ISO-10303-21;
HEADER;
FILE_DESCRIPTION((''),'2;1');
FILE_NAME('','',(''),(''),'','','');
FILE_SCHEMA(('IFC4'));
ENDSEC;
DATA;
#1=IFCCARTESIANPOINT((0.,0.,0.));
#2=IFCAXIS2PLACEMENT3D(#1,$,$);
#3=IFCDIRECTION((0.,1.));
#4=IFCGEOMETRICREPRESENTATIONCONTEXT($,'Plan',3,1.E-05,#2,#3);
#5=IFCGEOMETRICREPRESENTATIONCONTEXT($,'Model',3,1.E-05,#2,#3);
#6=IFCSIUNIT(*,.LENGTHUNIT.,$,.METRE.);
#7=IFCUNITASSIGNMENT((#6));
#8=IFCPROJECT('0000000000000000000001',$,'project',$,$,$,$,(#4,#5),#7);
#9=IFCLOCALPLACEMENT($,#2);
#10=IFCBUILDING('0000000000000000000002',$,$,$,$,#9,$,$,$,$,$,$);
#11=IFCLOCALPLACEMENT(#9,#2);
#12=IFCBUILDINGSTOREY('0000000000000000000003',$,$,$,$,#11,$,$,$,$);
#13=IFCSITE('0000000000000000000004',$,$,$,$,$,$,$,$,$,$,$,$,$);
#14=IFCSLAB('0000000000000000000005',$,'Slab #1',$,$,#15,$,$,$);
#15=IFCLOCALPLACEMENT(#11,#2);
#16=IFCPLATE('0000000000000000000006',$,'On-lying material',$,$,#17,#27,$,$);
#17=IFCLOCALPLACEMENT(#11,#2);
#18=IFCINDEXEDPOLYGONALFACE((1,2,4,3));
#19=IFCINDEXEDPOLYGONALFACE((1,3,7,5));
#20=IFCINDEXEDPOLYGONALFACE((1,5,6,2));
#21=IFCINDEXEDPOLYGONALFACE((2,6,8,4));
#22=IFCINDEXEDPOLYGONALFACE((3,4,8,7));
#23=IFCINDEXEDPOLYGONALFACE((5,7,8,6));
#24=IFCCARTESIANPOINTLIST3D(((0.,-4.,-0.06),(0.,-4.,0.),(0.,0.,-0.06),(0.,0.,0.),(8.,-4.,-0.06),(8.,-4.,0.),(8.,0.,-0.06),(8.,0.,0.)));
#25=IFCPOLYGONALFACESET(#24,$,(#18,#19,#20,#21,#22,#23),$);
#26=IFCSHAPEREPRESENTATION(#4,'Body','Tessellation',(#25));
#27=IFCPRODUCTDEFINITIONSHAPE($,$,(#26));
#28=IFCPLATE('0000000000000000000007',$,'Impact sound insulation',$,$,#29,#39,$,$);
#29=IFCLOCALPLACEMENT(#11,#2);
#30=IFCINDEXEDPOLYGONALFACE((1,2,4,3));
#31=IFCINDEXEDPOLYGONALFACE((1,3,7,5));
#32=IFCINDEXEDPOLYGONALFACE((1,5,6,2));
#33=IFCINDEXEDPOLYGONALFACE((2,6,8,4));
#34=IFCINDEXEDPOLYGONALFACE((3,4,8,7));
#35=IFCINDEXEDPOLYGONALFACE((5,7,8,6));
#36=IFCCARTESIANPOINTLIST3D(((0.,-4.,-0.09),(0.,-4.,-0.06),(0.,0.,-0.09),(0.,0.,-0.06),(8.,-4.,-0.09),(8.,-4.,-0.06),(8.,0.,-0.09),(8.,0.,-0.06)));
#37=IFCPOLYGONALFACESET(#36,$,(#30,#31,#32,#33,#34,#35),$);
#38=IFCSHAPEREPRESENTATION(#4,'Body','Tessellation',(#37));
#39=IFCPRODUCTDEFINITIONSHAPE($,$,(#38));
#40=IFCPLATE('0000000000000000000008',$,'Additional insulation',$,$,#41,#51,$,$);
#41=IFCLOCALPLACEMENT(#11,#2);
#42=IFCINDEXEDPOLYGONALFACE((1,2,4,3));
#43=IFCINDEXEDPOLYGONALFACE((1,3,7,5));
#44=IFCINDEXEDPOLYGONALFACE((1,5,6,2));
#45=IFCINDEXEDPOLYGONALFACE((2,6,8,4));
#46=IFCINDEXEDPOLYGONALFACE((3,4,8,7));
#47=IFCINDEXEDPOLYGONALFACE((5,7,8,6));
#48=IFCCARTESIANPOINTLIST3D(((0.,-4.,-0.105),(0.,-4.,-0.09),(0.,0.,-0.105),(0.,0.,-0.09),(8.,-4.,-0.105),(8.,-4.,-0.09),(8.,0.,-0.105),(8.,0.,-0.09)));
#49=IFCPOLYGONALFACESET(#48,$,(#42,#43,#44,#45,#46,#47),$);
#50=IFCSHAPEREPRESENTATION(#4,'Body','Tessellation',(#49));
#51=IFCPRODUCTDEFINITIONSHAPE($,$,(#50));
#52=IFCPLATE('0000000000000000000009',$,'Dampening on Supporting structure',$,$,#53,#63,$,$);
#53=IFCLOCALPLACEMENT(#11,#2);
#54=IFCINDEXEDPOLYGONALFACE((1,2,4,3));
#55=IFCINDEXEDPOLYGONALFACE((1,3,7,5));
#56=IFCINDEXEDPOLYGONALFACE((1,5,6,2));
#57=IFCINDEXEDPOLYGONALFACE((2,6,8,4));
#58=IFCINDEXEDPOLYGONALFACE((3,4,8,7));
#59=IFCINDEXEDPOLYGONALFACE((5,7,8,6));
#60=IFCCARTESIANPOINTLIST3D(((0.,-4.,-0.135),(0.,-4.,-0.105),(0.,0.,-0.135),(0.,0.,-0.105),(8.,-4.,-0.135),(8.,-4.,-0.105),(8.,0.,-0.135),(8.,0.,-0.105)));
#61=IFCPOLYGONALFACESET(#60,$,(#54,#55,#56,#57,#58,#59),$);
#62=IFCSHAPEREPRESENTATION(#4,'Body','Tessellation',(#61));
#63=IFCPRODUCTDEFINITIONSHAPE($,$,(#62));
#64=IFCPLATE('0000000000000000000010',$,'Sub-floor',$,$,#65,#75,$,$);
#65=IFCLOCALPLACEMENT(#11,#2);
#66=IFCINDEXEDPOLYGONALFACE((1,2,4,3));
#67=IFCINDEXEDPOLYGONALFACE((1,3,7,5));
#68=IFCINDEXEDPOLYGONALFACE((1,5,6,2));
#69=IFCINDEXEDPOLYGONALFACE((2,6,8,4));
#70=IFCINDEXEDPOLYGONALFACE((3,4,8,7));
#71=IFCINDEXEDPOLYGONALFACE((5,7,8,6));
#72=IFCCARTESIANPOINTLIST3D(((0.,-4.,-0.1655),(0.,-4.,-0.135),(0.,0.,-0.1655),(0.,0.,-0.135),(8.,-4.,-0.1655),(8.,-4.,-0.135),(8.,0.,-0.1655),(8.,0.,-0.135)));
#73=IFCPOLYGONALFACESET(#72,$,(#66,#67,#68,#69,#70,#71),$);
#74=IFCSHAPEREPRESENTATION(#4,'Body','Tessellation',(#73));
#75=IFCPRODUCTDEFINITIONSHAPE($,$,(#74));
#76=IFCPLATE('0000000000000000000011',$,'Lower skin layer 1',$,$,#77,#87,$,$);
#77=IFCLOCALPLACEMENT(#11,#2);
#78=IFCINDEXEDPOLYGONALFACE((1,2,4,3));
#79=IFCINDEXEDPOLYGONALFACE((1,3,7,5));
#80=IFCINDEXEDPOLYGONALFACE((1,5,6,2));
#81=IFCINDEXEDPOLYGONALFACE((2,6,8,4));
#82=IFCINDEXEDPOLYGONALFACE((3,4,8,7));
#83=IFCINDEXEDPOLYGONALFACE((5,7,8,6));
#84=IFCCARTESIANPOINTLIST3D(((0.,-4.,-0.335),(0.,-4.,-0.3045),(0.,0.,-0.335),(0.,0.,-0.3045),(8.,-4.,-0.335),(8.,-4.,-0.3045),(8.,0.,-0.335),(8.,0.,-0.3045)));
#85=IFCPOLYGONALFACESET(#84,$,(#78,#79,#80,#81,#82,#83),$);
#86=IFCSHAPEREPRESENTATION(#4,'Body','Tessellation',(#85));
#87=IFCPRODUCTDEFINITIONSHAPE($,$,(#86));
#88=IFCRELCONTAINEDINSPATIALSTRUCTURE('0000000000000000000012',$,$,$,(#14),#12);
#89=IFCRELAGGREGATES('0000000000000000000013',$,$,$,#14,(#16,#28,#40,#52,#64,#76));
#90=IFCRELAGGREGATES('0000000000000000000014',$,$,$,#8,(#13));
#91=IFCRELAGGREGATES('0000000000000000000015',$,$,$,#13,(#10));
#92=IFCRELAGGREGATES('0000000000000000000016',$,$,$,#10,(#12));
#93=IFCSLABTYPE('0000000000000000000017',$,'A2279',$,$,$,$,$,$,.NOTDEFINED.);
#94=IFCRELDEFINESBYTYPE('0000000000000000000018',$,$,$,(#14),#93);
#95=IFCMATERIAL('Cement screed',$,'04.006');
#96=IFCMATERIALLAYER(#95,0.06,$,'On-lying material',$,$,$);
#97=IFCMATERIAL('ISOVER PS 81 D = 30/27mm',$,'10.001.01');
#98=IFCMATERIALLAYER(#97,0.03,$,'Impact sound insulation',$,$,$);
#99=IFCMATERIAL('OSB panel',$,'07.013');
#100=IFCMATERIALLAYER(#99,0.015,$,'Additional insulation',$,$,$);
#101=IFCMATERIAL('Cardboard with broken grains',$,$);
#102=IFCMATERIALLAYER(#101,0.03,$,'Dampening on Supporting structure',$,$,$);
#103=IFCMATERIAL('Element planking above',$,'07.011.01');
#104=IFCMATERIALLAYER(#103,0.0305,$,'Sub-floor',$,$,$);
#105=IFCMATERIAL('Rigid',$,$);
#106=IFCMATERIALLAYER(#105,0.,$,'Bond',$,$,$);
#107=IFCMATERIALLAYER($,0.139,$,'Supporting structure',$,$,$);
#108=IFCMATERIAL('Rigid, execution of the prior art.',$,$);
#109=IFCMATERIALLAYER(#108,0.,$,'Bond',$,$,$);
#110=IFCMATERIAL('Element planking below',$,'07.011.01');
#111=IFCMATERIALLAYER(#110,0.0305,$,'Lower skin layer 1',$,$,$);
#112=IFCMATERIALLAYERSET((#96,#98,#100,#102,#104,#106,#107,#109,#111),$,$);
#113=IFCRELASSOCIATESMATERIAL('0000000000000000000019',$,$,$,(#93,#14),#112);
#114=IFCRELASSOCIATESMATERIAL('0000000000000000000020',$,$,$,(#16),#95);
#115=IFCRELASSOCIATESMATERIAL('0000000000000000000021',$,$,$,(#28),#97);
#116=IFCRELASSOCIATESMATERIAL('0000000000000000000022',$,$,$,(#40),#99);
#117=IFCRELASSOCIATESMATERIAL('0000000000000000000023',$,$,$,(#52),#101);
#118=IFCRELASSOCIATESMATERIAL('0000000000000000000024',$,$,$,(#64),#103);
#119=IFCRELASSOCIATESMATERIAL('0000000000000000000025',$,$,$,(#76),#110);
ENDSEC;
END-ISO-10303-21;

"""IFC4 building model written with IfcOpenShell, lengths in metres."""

from ifc_helpers import new_model, si_unit, direction, frame, frame_2d, origin, origin_with_axes, place, context, project, spatial, rectangle, extrude, material, layer, layer_set, type_object, element, aggregate, save


model = new_model("IFC4")

# Units and contexts
plan_context = context("Plan", 3, precision=1e-05, world=origin(), true_north=direction((0.0, 1.0)))
model_context = context("Model", 3, precision=1e-05, world=origin(), true_north=direction((0.0, 1.0)))
ifc_project = project(units=[si_unit("LENGTHUNIT", "METRE")], contexts=[plan_context, model_context])

# Site, building, storey
site = spatial("IfcSite", under=ifc_project)
building_placement = place(None, origin())
building = spatial("IfcBuilding", under=site, at=building_placement)
storey_placement = place(building_placement, origin())
storey = spatial("IfcBuildingStorey", under=building, at=storey_placement)

# Slab, plates
ifc_material_1 = material(Name="Cement screed", Category="04.006")
ifc_layer_1 = layer(ifc_material_1, 0.06, Name="On-lying material")
ifc_material_2 = material(Name="ISOVER PS 81 D = 30/27mm", Category="10.001.01")
ifc_layer_2 = layer(ifc_material_2, 0.03, Name="Impact sound insulation")
ifc_material_3 = material(Name="OSB panel", Category="07.013")
ifc_layer_3 = layer(ifc_material_3, 0.015, Name="Additional insulation")
ifc_material_4 = material(Name="Cardboard with broken grains")
ifc_layer_4 = layer(ifc_material_4, 0.03, Name="Dampening on Supporting structure")
ifc_material_5 = material(Name="Element planking above", Category="07.011.01")
ifc_layer_5 = layer(ifc_material_5, 0.0305, Name="Sub-floor")
ifc_material_6 = material(Name="Rigid")
ifc_layer_6 = layer(ifc_material_6, 0.0, Name="Bond")
ifc_layer_7 = layer(None, 0.139, Name="Supporting structure")
ifc_material_7 = material(Name="Rigid, execution of the prior art.")
ifc_layer_8 = layer(ifc_material_7, 0.0, Name="Bond")
ifc_material_8 = material(Name="Element planking below", Category="07.011.01")
ifc_layer_9 = layer(ifc_material_8, 0.0305, Name="Lower skin layer 1")
ifc_layer_set = layer_set([ifc_layer_1, ifc_layer_2, ifc_layer_3, ifc_layer_4, ifc_layer_5, ifc_layer_6, ifc_layer_7, ifc_layer_8, ifc_layer_9])
slab_type = type_object("IfcSlabType", Name="A2279", PredefinedType="NOTDEFINED", material=ifc_layer_set)
slab_placement = place(None, frame((0.0, 0.0, 0.0), z_axis=(0.0, 0.0, -1.0), x_axis=(1.0, 0.0, 0.0)))
slab = element("IfcSlab", 1, at=slab_placement, inside=storey, type_object=slab_type, material=ifc_layer_set, Name="Slab #1")
plate_1_placement = place(slab_placement, origin())
plate_1 = element("IfcPlate", 2, at=plate_1_placement, material=ifc_material_1, Name="On-lying material", context=plan_context, shape_type="SweptSolid", body=[
    extrude(rectangle(XDim=8.0, YDim=4.0, at=frame_2d((4.0, 2.0), x_axis=(1.0, 0.0))), origin_with_axes(), (0.0, 0.0, 1.0), 0.06),
])
plate_2_placement = place(slab_placement, origin())
plate_2 = element("IfcPlate", 3, at=plate_2_placement, material=ifc_material_2, Name="Impact sound insulation", context=plan_context, shape_type="SweptSolid", body=[
    extrude(rectangle(XDim=8.0, YDim=4.0, at=frame_2d((4.0, 2.0), x_axis=(1.0, 0.0))), frame((0.0, 0.0, 0.06), z_axis=(0.0, 0.0, 1.0), x_axis=(1.0, 0.0, 0.0)), (0.0, 0.0, 1.0), 0.03),
])
plate_3_placement = place(slab_placement, origin())
plate_3 = element("IfcPlate", 4, at=plate_3_placement, material=ifc_material_3, Name="Additional insulation", context=plan_context, shape_type="SweptSolid", body=[
    extrude(rectangle(XDim=8.0, YDim=4.0, at=frame_2d((4.0, 2.0), x_axis=(1.0, 0.0))), frame((0.0, 0.0, 0.09), z_axis=(0.0, 0.0, 1.0), x_axis=(1.0, 0.0, 0.0)), (0.0, 0.0, 1.0), 0.015),
])
plate_4_placement = place(slab_placement, origin())
plate_4 = element("IfcPlate", 5, at=plate_4_placement, material=ifc_material_4, Name="Dampening on Supporting structure", context=plan_context, shape_type="SweptSolid", body=[
    extrude(rectangle(XDim=8.0, YDim=4.0, at=frame_2d((4.0, 2.0), x_axis=(1.0, 0.0))), frame((0.0, 0.0, 0.105), z_axis=(0.0, 0.0, 1.0), x_axis=(1.0, 0.0, 0.0)), (0.0, 0.0, 1.0), 0.03),
])
plate_5_placement = place(slab_placement, origin())
plate_5 = element("IfcPlate", 6, at=plate_5_placement, material=ifc_material_5, Name="Sub-floor", context=plan_context, shape_type="SweptSolid", body=[
    extrude(rectangle(XDim=8.0, YDim=4.0, at=frame_2d((4.0, 2.0), x_axis=(1.0, 0.0))), frame((0.0, 0.0, 0.135), z_axis=(0.0, 0.0, 1.0), x_axis=(1.0, 0.0, 0.0)), (0.0, 0.0, 1.0), 0.0305),
])
plate_6_placement = place(slab_placement, origin())
plate_6 = element("IfcPlate", 7, at=plate_6_placement, material=ifc_material_8, Name="Lower skin layer 1", context=plan_context, shape_type="SweptSolid", body=[
    extrude(rectangle(XDim=8.0, YDim=4.0, at=frame_2d((4.0, 2.0), x_axis=(1.0, 0.0))), frame((0.0, 0.0, 0.3045), z_axis=(0.0, 0.0, 1.0), x_axis=(1.0, 0.0, 0.0)), (0.0, 0.0, 1.0), 0.0305),
])
aggregate(slab, [plate_1, plate_2, plate_3, plate_4, plate_5, plate_6])

save(model, "model.ifc")
